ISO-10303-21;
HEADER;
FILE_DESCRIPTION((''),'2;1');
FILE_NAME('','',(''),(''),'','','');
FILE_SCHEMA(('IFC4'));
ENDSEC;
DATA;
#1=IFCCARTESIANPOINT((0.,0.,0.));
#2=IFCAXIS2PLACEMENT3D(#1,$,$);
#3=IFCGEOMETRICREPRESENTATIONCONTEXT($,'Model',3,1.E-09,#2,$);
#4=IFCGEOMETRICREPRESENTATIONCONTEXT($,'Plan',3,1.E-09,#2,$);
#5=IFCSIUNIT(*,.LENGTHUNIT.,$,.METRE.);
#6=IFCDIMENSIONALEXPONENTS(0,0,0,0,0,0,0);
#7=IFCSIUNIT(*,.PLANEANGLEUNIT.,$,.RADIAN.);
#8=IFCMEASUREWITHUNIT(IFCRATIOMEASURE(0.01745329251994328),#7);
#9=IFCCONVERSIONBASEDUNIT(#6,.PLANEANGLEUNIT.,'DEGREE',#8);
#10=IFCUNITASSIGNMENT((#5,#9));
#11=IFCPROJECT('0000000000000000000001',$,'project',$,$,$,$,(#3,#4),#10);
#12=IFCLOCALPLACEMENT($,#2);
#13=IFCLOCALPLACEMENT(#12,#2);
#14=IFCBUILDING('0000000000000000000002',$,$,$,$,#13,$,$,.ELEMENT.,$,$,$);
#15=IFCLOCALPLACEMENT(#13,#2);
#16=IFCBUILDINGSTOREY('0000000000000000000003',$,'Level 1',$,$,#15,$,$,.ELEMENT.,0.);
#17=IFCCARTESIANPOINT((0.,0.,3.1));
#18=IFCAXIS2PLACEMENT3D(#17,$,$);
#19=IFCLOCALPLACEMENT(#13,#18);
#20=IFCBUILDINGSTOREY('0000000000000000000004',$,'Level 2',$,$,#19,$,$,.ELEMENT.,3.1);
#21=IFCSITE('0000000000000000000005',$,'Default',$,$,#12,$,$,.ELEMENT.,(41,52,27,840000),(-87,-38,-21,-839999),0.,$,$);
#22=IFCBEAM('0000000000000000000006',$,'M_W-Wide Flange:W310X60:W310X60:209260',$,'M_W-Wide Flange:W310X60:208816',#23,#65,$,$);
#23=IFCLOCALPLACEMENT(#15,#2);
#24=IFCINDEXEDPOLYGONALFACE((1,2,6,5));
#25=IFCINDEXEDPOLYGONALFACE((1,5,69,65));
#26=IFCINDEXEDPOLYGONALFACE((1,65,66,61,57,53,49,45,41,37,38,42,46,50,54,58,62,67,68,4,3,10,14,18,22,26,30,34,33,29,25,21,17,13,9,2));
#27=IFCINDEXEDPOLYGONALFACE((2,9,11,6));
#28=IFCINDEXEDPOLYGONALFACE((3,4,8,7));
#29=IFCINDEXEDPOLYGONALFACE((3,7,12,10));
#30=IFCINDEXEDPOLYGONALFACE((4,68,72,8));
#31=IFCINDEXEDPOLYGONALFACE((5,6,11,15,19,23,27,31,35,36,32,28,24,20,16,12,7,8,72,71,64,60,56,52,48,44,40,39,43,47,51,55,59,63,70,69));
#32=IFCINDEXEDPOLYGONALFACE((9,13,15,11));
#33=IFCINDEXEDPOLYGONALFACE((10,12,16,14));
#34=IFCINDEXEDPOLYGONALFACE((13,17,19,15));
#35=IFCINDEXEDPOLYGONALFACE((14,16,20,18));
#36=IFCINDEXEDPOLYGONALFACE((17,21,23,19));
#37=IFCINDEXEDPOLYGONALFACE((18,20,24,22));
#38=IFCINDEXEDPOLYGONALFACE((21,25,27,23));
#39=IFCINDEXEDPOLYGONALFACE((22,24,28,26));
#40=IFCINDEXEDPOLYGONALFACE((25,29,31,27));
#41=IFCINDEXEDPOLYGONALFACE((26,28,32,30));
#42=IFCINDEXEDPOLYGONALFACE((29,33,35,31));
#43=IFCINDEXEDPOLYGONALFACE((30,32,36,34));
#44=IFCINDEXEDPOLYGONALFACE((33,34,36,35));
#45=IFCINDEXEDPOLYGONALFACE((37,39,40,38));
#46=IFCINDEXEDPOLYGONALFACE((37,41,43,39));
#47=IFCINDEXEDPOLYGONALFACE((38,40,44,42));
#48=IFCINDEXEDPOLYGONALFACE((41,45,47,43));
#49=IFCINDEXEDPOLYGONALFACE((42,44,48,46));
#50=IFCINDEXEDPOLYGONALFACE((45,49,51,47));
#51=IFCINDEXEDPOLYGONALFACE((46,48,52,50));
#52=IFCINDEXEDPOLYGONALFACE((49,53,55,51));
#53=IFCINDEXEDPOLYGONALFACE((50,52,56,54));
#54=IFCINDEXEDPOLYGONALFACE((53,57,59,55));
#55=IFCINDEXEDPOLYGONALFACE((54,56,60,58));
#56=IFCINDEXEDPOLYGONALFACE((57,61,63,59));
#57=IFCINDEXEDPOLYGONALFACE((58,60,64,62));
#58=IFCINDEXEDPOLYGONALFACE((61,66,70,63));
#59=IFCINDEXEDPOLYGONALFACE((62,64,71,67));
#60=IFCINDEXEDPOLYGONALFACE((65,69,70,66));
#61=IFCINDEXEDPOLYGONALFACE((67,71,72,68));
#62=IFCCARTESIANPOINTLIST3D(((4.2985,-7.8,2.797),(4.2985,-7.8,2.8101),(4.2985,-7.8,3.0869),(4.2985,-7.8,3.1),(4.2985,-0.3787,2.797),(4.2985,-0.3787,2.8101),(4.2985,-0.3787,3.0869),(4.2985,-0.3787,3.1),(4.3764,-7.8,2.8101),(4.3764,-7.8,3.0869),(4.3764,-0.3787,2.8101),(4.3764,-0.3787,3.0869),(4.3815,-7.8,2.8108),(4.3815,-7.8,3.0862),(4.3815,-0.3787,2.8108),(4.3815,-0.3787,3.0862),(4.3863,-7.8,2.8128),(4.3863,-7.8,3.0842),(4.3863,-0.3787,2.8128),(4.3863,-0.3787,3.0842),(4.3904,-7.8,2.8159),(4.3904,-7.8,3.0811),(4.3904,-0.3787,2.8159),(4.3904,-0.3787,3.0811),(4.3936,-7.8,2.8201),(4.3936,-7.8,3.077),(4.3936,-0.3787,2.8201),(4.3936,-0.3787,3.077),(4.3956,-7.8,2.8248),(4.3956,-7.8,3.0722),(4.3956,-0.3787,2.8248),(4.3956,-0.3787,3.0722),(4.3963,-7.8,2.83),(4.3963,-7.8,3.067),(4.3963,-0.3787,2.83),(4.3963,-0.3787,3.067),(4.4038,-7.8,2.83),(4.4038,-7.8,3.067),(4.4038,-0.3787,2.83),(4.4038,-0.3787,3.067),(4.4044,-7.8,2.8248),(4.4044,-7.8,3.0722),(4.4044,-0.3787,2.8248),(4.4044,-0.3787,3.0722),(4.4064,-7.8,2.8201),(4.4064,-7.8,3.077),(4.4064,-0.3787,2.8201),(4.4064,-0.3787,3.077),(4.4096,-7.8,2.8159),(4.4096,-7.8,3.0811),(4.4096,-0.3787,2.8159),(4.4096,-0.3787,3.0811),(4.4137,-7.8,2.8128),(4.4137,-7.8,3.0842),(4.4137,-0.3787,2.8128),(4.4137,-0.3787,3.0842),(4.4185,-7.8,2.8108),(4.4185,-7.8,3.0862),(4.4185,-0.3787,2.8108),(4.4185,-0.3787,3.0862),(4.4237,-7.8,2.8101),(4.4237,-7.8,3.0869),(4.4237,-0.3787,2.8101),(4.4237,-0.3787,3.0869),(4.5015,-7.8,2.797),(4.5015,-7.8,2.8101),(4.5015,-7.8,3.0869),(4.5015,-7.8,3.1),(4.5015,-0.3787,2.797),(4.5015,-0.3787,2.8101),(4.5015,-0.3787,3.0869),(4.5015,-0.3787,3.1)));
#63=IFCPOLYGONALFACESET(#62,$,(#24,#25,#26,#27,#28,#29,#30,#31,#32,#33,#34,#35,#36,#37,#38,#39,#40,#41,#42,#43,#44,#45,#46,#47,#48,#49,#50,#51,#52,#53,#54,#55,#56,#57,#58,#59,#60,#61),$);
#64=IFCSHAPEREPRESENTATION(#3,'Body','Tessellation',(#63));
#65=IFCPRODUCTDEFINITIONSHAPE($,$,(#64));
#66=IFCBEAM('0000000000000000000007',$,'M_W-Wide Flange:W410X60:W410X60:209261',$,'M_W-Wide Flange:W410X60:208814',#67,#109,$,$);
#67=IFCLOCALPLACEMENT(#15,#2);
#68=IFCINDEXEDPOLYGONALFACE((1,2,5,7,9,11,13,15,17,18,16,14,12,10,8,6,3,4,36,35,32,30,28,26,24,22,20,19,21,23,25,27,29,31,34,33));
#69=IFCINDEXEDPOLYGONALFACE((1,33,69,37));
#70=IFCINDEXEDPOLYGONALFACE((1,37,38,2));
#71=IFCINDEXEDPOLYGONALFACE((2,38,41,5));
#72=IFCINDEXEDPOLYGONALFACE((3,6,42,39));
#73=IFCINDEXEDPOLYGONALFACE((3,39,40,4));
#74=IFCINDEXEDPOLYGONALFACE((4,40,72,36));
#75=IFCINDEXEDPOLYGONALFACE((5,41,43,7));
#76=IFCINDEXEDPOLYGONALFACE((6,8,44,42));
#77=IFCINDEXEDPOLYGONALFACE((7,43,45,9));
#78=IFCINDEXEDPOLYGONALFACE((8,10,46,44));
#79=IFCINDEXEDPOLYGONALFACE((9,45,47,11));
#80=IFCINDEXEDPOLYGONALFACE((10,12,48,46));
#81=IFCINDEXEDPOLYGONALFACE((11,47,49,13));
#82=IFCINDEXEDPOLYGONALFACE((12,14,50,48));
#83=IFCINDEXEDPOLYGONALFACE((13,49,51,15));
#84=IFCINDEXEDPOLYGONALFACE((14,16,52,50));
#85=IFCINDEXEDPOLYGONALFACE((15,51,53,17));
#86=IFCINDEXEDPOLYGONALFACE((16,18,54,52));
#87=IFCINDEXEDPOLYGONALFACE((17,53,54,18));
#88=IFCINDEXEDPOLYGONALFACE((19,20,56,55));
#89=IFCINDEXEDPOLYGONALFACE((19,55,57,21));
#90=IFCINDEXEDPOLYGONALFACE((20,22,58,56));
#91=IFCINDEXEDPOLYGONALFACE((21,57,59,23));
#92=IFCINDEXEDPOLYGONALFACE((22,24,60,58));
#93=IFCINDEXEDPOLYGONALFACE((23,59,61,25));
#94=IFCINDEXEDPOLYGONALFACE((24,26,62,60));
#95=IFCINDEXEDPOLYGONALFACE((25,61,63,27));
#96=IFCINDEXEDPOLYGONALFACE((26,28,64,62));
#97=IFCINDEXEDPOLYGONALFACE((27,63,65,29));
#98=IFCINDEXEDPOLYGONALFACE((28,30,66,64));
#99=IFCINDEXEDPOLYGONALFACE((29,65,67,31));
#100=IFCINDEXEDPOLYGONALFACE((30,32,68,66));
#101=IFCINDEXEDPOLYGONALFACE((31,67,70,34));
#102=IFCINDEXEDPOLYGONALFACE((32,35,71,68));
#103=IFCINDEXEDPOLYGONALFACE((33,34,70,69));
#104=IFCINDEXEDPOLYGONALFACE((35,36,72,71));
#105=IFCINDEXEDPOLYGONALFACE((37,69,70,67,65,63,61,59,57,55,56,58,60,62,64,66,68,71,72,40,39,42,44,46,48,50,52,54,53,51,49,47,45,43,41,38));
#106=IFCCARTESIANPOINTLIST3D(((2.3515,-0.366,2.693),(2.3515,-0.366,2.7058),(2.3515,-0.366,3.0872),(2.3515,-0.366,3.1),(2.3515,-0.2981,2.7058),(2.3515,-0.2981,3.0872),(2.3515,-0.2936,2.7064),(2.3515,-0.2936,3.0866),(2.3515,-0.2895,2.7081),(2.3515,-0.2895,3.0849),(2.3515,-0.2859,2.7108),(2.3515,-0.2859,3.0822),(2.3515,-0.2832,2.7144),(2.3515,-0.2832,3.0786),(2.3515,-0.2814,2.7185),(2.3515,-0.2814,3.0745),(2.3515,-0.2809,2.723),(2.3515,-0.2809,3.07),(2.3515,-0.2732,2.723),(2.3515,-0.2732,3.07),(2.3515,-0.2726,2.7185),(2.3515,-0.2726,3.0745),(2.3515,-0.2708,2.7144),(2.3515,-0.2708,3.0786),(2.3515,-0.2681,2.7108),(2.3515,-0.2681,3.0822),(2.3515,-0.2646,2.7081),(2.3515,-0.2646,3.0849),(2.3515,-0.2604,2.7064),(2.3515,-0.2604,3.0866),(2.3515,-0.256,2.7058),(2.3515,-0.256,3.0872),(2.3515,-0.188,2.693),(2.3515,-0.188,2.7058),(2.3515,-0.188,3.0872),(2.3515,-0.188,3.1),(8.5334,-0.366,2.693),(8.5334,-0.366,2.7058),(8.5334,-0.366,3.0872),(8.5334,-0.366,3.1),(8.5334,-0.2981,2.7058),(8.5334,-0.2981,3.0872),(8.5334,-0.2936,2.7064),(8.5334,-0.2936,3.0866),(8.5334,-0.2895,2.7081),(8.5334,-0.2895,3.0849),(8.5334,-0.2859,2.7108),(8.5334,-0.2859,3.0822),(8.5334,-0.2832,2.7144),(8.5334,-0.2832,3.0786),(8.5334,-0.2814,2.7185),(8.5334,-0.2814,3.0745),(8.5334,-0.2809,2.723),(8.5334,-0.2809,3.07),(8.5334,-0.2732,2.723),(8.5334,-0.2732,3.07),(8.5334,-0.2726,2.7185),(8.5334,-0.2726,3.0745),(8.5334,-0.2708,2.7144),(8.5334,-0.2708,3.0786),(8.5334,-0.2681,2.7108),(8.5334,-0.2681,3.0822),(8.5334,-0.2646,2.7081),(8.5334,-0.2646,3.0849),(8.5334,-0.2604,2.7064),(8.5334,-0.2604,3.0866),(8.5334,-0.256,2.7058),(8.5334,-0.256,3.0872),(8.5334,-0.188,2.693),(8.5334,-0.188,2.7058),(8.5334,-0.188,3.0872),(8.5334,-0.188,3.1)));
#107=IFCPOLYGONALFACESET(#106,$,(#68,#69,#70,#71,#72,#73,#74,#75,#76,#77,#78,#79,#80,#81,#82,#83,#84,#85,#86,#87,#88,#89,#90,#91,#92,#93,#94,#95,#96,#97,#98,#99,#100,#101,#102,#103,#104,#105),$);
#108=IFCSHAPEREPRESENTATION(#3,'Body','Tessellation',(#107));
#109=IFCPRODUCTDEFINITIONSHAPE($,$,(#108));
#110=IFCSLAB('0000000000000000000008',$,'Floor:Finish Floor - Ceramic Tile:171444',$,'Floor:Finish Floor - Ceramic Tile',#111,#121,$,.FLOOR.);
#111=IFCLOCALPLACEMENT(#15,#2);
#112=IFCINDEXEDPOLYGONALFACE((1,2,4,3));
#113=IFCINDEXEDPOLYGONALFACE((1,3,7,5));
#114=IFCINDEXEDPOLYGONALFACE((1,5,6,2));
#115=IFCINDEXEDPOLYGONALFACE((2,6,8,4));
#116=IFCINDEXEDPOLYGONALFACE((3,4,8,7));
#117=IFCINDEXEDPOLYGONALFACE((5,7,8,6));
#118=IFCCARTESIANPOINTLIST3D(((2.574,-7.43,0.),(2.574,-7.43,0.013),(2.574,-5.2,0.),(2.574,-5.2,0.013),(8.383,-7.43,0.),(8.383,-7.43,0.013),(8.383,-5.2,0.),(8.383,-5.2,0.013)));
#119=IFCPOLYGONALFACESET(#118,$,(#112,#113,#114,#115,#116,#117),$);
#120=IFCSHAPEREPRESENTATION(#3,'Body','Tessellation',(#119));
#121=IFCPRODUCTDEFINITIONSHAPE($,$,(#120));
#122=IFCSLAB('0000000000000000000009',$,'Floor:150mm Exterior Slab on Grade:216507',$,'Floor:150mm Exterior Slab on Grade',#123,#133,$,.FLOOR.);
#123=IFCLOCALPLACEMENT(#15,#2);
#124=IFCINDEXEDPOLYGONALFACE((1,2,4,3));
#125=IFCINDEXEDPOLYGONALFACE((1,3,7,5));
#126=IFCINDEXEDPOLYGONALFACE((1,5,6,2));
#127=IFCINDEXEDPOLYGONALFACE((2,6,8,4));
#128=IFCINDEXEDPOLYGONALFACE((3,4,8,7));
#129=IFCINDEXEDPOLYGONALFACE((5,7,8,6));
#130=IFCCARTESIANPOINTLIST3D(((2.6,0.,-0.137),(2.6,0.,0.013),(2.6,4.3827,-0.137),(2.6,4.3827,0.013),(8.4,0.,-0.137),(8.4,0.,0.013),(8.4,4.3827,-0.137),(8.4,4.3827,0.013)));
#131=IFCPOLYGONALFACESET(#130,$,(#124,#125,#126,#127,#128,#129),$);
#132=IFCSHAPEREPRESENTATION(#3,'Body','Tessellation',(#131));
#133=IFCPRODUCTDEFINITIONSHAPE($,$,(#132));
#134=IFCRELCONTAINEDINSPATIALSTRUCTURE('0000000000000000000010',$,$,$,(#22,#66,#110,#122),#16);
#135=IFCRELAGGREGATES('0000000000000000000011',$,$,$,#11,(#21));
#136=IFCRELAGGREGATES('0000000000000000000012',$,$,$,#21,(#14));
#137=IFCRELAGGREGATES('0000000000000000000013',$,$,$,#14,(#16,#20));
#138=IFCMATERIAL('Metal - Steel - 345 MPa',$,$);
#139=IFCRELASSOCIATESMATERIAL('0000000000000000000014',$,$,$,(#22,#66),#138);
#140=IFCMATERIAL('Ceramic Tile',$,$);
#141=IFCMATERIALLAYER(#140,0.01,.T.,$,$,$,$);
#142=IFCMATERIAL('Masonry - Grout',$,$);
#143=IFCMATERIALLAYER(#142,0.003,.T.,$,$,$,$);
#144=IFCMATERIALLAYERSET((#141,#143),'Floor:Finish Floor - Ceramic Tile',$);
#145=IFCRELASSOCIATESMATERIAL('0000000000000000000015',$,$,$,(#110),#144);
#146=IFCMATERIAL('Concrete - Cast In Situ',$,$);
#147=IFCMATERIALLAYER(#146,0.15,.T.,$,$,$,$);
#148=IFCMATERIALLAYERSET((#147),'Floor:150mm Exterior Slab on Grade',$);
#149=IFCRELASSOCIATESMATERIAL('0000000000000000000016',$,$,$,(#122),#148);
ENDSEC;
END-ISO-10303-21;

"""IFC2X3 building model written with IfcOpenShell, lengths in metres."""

from ifc_helpers import new_model, entity, si_unit, converted_unit, frame, frame_2d, origin, place, context, project, spatial, polyline, circle_curve, parameter, trimmed, segment, composite_curve, rectangle, outline, extrude, material, layer, layer_set, layer_usage, element, save


model = new_model("IFC2X3")

# Units and contexts
model_context = context("Model", 3, precision=1e-09, world=origin())
plan_context = context("Plan", 3, precision=1e-09, world=origin())
ifc_project = project(units=[si_unit("LENGTHUNIT", "METRE"), converted_unit("PLANEANGLEUNIT", "DEGREE", entity("IfcRatioMeasure", 0.01745329251994328), si_unit("PLANEANGLEUNIT", "RADIAN"), dimensions=[0, 0, 0, 0, 0, 0, 0])], contexts=[model_context, plan_context])

# Site, building, storey
site_placement = place(None, origin())
site = spatial("IfcSite", under=ifc_project, at=site_placement, Name="Default", CompositionType="ELEMENT", RefLatitude=(41, 52, 27, 840000), RefLongitude=(-87, -38, -21, -839999), RefElevation=0.0)
building_placement = place(site_placement, origin())
building = spatial("IfcBuilding", under=site, at=building_placement, CompositionType="ELEMENT")
storey_1_placement = place(building_placement, origin())
storey_1 = spatial("IfcBuildingStorey", under=building, at=storey_1_placement, Name="Level 1", CompositionType="ELEMENT", Elevation=0.0)

# Beam
ifc_material_1 = material(Name="Metal - Steel - 345 MPa")
beam_1_placement = place(storey_1_placement, frame((4.4, -7.8, 3.1)))
element("IfcBeam", 1, at=beam_1_placement, inside=storey_1, material=ifc_material_1, Name="M_W-Wide Flange:W310X60:W310X60:209260", ObjectType="M_W-Wide Flange:W310X60:208816", context=model_context, shape_type="SweptSolid", body=[
    extrude(outline(composite_curve([segment(polyline([(-0.1015, -0.1384), (-0.1015, -0.1515)]), True, "CONTINUOUS"), segment(polyline([(-0.1015, -0.1515), (0.1015, -0.1515)]), True, "CONTINUOUS"), segment(polyline([(0.1015, -0.1515), (0.1015, -0.1384)]), True, "CONTINUOUS"), segment(polyline([(0.1015, -0.1384), (0.0236, -0.1384)]), True, "CONTINUOUS"), segment(trimmed(circle_curve(frame_2d((0.0236, -0.1185), x_axis=(1.0, 0.0)), 0.0199), [parameter(180.0)], [parameter(270.0)], True, "PARAMETER"), False, "CONTINUOUS"), segment(polyline([(0.0037, -0.1185), (0.0037, 0.1185)]), True, "CONTINUOUS"), segment(trimmed(circle_curve(frame_2d((0.0236, 0.1185), x_axis=(1.0, 0.0)), 0.0199), [parameter(90.0)], [parameter(180.0)], True, "PARAMETER"), False, "CONTINUOUS"), segment(polyline([(0.0236, 0.1384), (0.1015, 0.1384)]), True, "CONTINUOUS"), segment(polyline([(0.1015, 0.1384), (0.1015, 0.1515)]), True, "CONTINUOUS"), segment(polyline([(0.1015, 0.1515), (-0.1015, 0.1515)]), True, "CONTINUOUS"), segment(polyline([(-0.1015, 0.1515), (-0.1015, 0.1384)]), True, "CONTINUOUS"), segment(polyline([(-0.1015, 0.1384), (-0.0237, 0.1384)]), True, "CONTINUOUS"), segment(trimmed(circle_curve(frame_2d((-0.0237, 0.1185), x_axis=(1.0, 0.0)), 0.0199), [parameter(360.0)], [parameter(90.0)], True, "PARAMETER"), False, "CONTINUOUS"), segment(polyline([(-0.0038, 0.1185), (-0.0038, -0.1185)]), True, "CONTINUOUS"), segment(trimmed(circle_curve(frame_2d((-0.0237, -0.1185), x_axis=(1.0, 0.0)), 0.0199), [parameter(270.0)], [parameter(0.0)], True, "PARAMETER"), False, "CONTINUOUS"), segment(polyline([(-0.0237, -0.1384), (-0.1015, -0.1384)]), True, "CONTINUOUS")], self_intersect=False)), frame((0.0, 0.0, -0.1515), z_axis=(0.0, -1.0, 0.0), x_axis=(1.0, 0.0, 0.0)), (0.0, 0.0, -1.0), 7.4213),
])

# Beam
beam_2_placement = place(storey_1_placement, frame((8.5915, -0.277, 3.1), z_axis=(0.0, 0.0, 1.0), x_axis=(0.0, 1.0, 0.0)))
element("IfcBeam", 2, at=beam_2_placement, inside=storey_1, material=ifc_material_1, Name="M_W-Wide Flange:W410X60:W410X60:209261", ObjectType="M_W-Wide Flange:W410X60:208814", context=model_context, shape_type="SweptSolid", body=[
    extrude(outline(composite_curve([segment(polyline([(0.1907, -0.089), (0.2035, -0.089)]), True, "CONTINUOUS"), segment(polyline([(0.2035, -0.089), (0.2035, 0.089)]), True, "CONTINUOUS"), segment(polyline([(0.2035, 0.089), (0.1907, 0.089)]), True, "CONTINUOUS"), segment(polyline([(0.1907, 0.089), (0.1907, 0.021)]), True, "CONTINUOUS"), segment(trimmed(circle_curve(frame_2d((0.1735, 0.021), x_axis=(1.0, 0.0)), 0.0172), [parameter(270.0)], [parameter(360.0)], True, "PARAMETER"), False, "CONTINUOUS"), segment(polyline([(0.1735, 0.0038), (-0.1735, 0.0038)]), True, "CONTINUOUS"), segment(trimmed(circle_curve(frame_2d((-0.1735, 0.021), x_axis=(0.0, -1.0)), 0.0172), [parameter(270.0)], [parameter(360.0)], True, "PARAMETER"), False, "CONTINUOUS"), segment(polyline([(-0.1907, 0.021), (-0.1907, 0.089)]), True, "CONTINUOUS"), segment(polyline([(-0.1907, 0.089), (-0.2035, 0.089)]), True, "CONTINUOUS"), segment(polyline([(-0.2035, 0.089), (-0.2035, -0.089)]), True, "CONTINUOUS"), segment(polyline([(-0.2035, -0.089), (-0.1907, -0.089)]), True, "CONTINUOUS"), segment(polyline([(-0.1907, -0.089), (-0.1907, -0.0211)]), True, "CONTINUOUS"), segment(trimmed(circle_curve(frame_2d((-0.1735, -0.0211), x_axis=(-1.0, 0.0)), 0.0172), [parameter(270.0)], [parameter(0.0)], True, "PARAMETER"), False, "CONTINUOUS"), segment(polyline([(-0.1735, -0.0039), (0.1735, -0.0039)]), True, "CONTINUOUS"), segment(trimmed(circle_curve(frame_2d((0.1735, -0.0211), x_axis=(0.0, 1.0)), 0.0172), [parameter(270.0)], [parameter(0.0)], True, "PARAMETER"), False, "CONTINUOUS"), segment(polyline([(0.1907, -0.0211), (0.1907, -0.089)]), True, "CONTINUOUS")], self_intersect=False)), frame((0.0, 6.24, -0.2035), z_axis=(0.0, -1.0, 0.0), x_axis=(0.0, 0.0, -1.0)), (0.0, 0.0, 1.0), 6.1819),
])

# Slabs
ifc_material_2 = material(Name="Ceramic Tile")
ifc_layer_1 = layer(ifc_material_2, 0.01, ventilated=True)
ifc_material_3 = material(Name="Masonry - Grout")
ifc_layer_2 = layer(ifc_material_3, 0.003, ventilated=True)
ifc_layer_set_1 = layer_set([ifc_layer_1, ifc_layer_2], Name="Floor:Finish Floor - Ceramic Tile")
ifc_layer_usage_1 = layer_usage(ifc_layer_set_1, "AXIS3", "POSITIVE", 0.0)
slab_1_placement = place(storey_1_placement, frame((2.574, -7.43, 0.0)))
element("IfcSlab", 3, at=slab_1_placement, inside=storey_1, material=ifc_layer_usage_1, Name="Floor:Finish Floor - Ceramic Tile:171444", ObjectType="Floor:Finish Floor - Ceramic Tile", PredefinedType="FLOOR", context=model_context, shape_type="SweptSolid", body=[
    extrude(rectangle(XDim=5.809, YDim=2.23, at=frame_2d((0.0, 0.0), x_axis=(-1.0, 0.0))), frame((2.9045, 1.115, 0.013), z_axis=(0.0, 0.0, -1.0), x_axis=(-1.0, 0.0, 0.0)), (0.0, 0.0, 1.0), 0.013),
])
ifc_material_4 = material(Name="Concrete - Cast In Situ")
ifc_layer_3 = layer(ifc_material_4, 0.15, ventilated=True)
ifc_layer_set_2 = layer_set([ifc_layer_3], Name="Floor:150mm Exterior Slab on Grade")
ifc_layer_usage_2 = layer_usage(ifc_layer_set_2, "AXIS3", "POSITIVE", 0.0)
slab_2_placement = place(storey_1_placement, frame((2.6, 0.0, -0.137)))
element("IfcSlab", 4, at=slab_2_placement, inside=storey_1, material=ifc_layer_usage_2, Name="Floor:150mm Exterior Slab on Grade:216507", ObjectType="Floor:150mm Exterior Slab on Grade", PredefinedType="FLOOR", context=model_context, shape_type="SweptSolid", body=[
    extrude(rectangle(XDim=5.8, YDim=4.3827, at=frame_2d((0.0, 0.0), x_axis=(-1.0, 0.0))), frame((2.9, 2.1914, 0.15), z_axis=(0.0, 0.0, -1.0), x_axis=(-1.0, 0.0, 0.0)), (0.0, 0.0, 1.0), 0.15),
])

# Shared definitions
storey_2_placement = place(building_placement, frame((0.0, 0.0, 3.1)))
storey_2 = spatial("IfcBuildingStorey", under=building, at=storey_2_placement, Name="Level 2", CompositionType="ELEMENT", Elevation=3.1)

save(model, "model.ifc")
